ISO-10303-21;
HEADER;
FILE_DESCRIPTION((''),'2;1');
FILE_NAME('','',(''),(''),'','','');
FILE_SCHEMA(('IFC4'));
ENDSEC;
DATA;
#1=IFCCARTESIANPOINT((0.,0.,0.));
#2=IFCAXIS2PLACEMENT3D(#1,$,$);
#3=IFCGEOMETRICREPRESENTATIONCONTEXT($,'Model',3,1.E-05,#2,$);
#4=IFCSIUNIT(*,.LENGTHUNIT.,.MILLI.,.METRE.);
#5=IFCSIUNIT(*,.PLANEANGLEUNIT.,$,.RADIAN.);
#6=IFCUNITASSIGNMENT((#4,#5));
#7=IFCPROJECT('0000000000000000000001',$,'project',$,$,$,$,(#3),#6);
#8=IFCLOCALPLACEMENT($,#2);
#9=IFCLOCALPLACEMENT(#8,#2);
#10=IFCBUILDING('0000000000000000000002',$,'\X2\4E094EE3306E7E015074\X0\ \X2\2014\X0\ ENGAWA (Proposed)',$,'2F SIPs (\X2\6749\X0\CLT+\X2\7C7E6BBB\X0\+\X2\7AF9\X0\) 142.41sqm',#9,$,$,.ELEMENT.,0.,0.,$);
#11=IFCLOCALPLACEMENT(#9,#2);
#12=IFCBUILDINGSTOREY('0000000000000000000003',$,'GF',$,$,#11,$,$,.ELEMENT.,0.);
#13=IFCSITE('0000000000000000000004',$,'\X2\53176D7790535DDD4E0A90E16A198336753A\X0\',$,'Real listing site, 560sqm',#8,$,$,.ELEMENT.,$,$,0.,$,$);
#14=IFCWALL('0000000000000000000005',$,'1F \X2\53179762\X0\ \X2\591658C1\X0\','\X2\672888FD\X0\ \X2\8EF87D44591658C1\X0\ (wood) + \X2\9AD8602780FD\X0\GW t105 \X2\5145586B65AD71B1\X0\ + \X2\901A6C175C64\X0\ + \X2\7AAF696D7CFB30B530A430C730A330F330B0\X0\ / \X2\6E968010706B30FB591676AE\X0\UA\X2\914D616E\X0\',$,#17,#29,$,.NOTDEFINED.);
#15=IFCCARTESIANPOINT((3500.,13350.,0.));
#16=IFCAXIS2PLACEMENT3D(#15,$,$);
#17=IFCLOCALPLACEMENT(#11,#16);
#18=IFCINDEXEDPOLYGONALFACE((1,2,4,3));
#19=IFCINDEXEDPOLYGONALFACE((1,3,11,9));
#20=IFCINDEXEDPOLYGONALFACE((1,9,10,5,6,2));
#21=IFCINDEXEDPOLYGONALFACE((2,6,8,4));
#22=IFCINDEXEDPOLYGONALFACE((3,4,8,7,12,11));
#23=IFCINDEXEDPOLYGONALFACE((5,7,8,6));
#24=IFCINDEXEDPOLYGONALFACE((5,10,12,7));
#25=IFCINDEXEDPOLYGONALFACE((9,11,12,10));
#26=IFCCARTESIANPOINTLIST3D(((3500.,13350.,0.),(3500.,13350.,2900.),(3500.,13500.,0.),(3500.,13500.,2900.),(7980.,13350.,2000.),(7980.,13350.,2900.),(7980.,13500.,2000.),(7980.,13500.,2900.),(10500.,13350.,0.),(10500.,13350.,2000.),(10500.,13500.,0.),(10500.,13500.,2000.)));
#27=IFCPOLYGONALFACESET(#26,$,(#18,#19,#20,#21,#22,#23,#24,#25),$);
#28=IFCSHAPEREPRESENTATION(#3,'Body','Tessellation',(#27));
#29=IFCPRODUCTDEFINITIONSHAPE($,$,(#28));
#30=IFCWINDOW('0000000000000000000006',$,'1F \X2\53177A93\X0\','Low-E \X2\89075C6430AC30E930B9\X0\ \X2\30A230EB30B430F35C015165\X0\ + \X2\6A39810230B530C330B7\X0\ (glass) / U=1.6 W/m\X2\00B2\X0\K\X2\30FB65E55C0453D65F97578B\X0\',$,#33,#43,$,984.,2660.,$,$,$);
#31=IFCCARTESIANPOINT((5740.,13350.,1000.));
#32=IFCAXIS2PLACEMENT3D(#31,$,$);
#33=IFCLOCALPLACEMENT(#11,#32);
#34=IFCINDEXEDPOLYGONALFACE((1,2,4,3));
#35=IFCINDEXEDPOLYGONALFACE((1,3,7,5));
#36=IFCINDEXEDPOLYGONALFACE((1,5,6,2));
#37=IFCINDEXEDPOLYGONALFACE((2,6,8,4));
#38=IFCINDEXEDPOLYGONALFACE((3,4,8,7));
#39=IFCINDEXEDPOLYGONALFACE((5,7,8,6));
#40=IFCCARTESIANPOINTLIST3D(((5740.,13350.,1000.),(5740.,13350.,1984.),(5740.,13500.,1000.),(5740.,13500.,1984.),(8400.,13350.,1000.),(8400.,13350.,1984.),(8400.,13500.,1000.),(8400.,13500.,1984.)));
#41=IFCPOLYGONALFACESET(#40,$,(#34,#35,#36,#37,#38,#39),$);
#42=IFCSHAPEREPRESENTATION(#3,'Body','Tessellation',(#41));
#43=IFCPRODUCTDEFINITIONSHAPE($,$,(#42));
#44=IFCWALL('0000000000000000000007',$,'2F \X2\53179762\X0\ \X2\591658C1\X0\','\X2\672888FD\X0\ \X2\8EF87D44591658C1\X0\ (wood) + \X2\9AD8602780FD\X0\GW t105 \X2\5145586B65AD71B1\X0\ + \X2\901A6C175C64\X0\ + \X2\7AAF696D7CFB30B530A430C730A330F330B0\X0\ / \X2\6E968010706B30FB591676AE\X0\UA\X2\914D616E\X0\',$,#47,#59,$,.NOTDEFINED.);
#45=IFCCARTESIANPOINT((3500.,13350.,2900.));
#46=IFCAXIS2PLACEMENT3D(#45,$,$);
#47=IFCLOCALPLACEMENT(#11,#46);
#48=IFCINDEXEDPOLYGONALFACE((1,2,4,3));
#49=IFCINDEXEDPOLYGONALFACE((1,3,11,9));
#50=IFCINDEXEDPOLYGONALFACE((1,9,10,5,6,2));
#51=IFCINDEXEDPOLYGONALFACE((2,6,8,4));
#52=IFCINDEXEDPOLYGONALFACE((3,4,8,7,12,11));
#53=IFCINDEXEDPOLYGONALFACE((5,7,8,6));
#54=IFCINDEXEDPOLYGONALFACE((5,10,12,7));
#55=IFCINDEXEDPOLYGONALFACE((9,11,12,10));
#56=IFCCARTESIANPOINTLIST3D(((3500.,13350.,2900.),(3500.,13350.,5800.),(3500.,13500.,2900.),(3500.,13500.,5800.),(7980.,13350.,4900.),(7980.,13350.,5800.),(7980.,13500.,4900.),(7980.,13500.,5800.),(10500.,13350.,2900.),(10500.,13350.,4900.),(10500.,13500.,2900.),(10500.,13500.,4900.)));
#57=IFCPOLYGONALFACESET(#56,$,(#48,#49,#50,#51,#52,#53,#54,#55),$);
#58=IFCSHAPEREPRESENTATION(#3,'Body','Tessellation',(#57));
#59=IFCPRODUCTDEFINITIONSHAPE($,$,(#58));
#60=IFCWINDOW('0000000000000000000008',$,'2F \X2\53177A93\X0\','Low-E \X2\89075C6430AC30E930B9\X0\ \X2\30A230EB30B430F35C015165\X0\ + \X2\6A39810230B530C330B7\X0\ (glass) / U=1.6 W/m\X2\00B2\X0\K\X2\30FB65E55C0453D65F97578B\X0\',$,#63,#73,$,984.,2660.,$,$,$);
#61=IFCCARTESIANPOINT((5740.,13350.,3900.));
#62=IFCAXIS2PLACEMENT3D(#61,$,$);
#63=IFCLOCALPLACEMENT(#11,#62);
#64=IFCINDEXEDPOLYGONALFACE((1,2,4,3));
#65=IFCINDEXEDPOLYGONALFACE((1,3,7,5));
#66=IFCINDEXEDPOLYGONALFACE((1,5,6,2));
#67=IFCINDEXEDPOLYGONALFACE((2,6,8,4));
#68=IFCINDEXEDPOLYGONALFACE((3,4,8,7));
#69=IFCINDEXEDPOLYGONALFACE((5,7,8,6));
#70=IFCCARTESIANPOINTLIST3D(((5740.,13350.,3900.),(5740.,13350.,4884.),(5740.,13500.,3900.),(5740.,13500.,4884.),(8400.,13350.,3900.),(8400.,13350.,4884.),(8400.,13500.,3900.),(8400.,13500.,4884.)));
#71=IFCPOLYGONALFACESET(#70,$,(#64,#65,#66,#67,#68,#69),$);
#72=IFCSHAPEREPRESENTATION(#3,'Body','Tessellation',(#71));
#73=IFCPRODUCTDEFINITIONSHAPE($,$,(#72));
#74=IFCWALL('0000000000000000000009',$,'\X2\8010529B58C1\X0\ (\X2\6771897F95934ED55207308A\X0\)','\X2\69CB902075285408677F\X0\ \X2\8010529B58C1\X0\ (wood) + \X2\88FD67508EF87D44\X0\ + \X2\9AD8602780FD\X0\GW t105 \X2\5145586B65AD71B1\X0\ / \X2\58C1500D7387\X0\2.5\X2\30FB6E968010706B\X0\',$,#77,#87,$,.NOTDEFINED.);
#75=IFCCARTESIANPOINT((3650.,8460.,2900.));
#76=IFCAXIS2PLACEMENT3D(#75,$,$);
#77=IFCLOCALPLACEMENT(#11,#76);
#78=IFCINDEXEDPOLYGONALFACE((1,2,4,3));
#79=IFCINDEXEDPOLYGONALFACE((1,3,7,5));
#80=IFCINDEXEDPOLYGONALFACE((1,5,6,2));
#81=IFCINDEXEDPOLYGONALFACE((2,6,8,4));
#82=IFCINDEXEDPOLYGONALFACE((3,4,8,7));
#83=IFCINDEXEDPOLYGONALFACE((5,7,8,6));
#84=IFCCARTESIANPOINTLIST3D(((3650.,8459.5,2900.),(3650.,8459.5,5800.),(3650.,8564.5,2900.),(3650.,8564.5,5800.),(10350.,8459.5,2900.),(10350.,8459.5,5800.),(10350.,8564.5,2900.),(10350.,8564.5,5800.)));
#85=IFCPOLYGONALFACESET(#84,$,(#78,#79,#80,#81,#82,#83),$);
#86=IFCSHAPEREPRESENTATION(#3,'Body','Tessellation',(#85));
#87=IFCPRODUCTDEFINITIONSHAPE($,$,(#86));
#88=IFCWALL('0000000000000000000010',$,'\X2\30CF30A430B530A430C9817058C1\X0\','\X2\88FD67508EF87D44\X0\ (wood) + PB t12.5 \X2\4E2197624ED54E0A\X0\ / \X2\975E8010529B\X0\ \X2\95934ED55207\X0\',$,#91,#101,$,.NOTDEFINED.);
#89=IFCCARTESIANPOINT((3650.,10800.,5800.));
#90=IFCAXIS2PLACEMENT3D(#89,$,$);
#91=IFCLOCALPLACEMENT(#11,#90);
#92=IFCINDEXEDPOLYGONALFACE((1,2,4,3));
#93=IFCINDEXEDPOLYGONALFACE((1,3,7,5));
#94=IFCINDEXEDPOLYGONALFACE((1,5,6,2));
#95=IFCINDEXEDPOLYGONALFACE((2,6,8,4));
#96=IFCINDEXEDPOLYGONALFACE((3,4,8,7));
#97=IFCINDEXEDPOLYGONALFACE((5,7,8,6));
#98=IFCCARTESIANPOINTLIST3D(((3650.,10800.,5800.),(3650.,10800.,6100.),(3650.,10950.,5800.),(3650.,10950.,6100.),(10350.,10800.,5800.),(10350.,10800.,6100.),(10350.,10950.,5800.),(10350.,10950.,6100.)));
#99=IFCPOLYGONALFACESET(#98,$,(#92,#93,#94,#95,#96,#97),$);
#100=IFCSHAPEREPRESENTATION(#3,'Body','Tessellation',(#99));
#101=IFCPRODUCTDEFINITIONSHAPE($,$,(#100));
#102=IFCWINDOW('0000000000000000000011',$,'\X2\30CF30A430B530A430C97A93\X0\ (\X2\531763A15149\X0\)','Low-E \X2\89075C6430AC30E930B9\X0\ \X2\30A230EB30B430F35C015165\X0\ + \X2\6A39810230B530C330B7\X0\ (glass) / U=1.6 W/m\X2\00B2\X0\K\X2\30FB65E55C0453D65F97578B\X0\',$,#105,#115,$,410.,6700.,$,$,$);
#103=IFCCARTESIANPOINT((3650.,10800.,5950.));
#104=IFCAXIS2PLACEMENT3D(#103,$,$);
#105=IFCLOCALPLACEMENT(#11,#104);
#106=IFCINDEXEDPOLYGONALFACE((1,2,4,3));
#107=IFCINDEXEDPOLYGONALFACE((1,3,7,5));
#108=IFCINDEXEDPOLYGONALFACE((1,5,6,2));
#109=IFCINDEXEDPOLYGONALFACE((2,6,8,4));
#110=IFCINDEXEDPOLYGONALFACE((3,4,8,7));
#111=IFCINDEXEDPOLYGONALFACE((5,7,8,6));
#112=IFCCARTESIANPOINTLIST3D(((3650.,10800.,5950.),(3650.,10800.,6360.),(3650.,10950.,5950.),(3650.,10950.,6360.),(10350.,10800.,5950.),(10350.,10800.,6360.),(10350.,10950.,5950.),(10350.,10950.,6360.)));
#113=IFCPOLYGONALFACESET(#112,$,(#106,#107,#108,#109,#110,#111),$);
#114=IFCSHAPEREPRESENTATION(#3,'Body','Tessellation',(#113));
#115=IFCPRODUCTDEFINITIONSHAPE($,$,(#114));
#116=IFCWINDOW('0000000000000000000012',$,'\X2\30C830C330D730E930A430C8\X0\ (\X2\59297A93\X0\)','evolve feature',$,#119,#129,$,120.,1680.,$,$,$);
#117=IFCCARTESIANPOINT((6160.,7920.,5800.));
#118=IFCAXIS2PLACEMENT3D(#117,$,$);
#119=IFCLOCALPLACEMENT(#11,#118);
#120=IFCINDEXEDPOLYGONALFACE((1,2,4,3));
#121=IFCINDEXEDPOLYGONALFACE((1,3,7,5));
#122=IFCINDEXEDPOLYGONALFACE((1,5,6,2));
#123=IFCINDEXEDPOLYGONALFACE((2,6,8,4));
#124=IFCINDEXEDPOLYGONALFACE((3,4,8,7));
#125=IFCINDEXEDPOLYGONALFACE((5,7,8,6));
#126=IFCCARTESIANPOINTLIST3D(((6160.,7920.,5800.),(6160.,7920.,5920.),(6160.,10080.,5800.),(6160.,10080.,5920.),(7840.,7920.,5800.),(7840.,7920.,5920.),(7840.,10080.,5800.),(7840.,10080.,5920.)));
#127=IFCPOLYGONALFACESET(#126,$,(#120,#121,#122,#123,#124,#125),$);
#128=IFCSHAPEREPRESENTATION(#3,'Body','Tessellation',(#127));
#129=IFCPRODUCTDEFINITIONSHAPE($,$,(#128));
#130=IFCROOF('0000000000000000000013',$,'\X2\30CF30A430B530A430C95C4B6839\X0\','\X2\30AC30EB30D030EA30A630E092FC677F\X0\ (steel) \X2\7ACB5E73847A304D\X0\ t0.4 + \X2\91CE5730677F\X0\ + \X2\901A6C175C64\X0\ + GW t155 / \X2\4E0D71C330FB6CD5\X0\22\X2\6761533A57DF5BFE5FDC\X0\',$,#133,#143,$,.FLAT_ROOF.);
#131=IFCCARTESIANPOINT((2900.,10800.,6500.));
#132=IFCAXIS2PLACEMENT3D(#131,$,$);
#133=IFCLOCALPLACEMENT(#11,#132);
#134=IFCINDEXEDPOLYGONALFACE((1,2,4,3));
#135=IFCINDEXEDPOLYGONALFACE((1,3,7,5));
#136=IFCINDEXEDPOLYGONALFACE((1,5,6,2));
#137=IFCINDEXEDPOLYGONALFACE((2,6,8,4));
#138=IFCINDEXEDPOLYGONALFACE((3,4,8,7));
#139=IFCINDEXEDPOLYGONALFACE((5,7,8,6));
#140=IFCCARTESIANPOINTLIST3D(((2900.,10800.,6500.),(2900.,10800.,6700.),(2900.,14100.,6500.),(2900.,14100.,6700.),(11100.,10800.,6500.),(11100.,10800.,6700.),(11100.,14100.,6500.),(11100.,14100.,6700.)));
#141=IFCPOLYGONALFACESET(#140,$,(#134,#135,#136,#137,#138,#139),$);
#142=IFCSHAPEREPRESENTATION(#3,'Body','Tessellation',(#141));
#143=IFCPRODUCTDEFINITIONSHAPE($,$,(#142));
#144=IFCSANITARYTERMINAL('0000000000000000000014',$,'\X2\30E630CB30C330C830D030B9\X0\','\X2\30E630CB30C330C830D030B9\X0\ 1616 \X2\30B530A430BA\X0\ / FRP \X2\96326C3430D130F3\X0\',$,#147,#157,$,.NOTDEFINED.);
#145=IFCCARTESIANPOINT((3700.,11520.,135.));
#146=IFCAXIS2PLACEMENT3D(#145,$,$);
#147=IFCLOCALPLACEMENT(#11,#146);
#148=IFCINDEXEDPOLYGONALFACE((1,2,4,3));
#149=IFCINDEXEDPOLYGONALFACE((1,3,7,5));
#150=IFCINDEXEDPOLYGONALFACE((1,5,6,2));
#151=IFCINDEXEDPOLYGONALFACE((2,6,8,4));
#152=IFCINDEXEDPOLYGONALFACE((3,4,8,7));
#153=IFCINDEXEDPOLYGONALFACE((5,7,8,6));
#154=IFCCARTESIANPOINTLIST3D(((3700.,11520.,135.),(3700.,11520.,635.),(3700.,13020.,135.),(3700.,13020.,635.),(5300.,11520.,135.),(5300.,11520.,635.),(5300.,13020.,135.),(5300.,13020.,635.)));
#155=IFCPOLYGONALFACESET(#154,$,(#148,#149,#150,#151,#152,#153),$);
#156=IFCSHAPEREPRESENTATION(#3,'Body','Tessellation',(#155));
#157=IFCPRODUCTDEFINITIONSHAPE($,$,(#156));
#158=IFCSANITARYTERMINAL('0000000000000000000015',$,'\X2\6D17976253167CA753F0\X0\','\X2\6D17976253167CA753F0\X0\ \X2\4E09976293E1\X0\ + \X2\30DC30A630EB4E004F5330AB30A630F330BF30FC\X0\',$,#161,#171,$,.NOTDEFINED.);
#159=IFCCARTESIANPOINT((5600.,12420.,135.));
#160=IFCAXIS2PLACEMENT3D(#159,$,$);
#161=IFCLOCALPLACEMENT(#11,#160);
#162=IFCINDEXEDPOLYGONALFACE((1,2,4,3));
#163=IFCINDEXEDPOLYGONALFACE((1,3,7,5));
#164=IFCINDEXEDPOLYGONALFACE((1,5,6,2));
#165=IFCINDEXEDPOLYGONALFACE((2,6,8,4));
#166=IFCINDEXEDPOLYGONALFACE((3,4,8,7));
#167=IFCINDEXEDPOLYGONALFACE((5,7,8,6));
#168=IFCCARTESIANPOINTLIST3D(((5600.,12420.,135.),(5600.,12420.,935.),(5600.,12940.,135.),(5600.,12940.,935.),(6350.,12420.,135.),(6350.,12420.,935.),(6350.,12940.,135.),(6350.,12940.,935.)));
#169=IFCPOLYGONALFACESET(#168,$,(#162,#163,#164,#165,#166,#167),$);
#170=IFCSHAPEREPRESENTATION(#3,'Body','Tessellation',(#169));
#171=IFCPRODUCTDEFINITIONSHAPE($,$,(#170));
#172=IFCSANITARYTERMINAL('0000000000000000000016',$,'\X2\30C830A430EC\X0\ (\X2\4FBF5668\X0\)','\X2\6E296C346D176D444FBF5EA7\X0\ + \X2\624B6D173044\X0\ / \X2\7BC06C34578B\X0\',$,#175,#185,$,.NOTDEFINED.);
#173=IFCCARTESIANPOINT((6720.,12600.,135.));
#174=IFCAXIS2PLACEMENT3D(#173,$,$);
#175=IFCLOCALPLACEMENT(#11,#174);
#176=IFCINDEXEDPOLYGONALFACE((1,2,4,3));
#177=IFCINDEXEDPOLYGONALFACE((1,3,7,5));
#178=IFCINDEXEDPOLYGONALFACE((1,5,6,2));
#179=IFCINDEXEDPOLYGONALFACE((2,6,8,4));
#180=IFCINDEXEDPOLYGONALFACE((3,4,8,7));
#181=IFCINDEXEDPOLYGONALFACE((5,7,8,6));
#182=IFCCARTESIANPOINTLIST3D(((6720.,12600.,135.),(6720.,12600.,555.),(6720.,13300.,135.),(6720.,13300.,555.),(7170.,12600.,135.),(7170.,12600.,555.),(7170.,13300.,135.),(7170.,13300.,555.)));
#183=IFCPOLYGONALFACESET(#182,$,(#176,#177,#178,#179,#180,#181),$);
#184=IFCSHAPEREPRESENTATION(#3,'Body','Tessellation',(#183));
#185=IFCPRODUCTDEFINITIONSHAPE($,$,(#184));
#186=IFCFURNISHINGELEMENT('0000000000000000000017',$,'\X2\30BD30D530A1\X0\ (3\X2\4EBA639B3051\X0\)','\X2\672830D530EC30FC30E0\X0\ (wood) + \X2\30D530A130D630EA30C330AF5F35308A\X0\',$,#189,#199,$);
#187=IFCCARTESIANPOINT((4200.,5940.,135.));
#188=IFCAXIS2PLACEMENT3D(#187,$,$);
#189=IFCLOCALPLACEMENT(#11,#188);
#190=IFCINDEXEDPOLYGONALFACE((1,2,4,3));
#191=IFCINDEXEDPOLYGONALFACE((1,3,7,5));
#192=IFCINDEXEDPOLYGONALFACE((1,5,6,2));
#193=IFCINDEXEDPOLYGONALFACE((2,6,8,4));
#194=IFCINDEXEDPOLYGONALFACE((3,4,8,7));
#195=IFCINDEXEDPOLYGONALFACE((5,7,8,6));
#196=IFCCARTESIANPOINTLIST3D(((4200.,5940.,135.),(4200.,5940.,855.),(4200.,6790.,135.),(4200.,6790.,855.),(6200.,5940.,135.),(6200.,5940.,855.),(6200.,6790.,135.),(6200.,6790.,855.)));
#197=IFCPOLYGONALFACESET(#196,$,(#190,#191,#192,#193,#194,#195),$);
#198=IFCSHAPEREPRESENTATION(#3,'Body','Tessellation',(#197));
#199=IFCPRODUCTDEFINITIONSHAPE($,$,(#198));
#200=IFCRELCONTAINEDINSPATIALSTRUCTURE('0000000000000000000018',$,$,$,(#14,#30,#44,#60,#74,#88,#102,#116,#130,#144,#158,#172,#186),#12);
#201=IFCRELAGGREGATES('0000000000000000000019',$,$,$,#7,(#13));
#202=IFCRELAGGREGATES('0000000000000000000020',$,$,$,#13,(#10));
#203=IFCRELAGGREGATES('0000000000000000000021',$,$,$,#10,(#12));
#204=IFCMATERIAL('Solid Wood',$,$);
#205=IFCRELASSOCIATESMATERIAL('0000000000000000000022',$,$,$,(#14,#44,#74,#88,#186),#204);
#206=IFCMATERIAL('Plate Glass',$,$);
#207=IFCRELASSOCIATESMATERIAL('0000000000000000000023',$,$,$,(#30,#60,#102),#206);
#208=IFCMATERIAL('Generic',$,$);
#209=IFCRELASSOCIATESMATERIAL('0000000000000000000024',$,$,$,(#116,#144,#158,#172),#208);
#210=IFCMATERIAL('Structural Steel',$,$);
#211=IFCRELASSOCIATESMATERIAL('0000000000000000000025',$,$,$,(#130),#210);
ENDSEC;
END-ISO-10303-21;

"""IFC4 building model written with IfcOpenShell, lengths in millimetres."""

from ifc_helpers import new_model, si_unit, frame, frame_2d, origin, place, context, project, spatial, rectangle, extrude, material, element, fill, save


model = new_model("IFC4")

# Units and contexts
model_context = context("Model", 3, precision=1e-05, world=origin())
ifc_project = project(units=[si_unit("LENGTHUNIT", "METRE", prefix="MILLI"), si_unit("PLANEANGLEUNIT", "RADIAN")], contexts=[model_context])

# Site, building, storey
site_placement = place(None, origin())
site = spatial("IfcSite", under=ifc_project, at=site_placement, Name="北海道川上郡標茶町", ObjectType="Real listing site, 560sqm", CompositionType="ELEMENT", RefElevation=0.0)
building_placement = place(site_placement, origin())
building = spatial("IfcBuilding", under=site, at=building_placement, Name="三代の縁側 — ENGAWA (Proposed)", ObjectType="2F SIPs (杉CLT+籾殻+竹) 142.41sqm", CompositionType="ELEMENT", ElevationOfRefHeight=0.0, ElevationOfTerrain=0.0)
storey_placement = place(building_placement, origin())
storey = spatial("IfcBuildingStorey", under=building, at=storey_placement, Name="GF", CompositionType="ELEMENT", Elevation=0.0)

# Wall, opening, window
ifc_material_1 = material(Name="Solid Wood")
wall_1_placement = place(storey_placement, frame((3500.0, 13350.0, 0.0)))
wall_1 = element("IfcWall", 1, at=wall_1_placement, inside=storey, material=ifc_material_1, Name="1F 北面 外壁", Description="木製 軸組外壁 (wood) + 高性能GW t105 充填断熱 + 通気層 + 窯業系サイディング / 準耐火・外皮UA配慮", PredefinedType="NOTDEFINED", context=model_context, shape_type="SweptSolid", body=[
    extrude(rectangle(XDim=7000.0, YDim=150.0, at=frame_2d((3500.0, 75.0))), frame((3500.0, 13350.0, 0.0)), (0.0, 0.0, 1.0), 2900.0),
])
opening_1_placement = place(storey_placement, frame((5740.0, 13350.0, 1000.0)))
opening_1 = element("IfcOpeningElement", 2, at=opening_1_placement, cuts=wall_1, PredefinedType="NOTDEFINED", context=model_context, shape_type="SweptSolid", body=[
    extrude(rectangle(XDim=2660.0, YDim=150.0, at=frame_2d((1330.0, 75.0))), frame((5740.0, 13350.0, 1000.0)), (0.0, 0.0, 1.0), 984.0),
])
ifc_material_2 = material(Name="Plate Glass")
window_1_placement = place(storey_placement, frame((5740.0, 13350.0, 1000.0)))
window_1 = element("IfcWindow", 3, at=window_1_placement, inside=storey, material=ifc_material_2, Name="1F 北窓", Description="Low-E 複層ガラス アルゴン封入 + 樹脂サッシ (glass) / U=1.6 W/m²K・日射取得型", OverallHeight=984.0, OverallWidth=2660.0, context=model_context, shape_type="SweptSolid", body=[
    extrude(rectangle(XDim=2660.0, YDim=150.0, at=frame_2d((1330.0, 75.0))), frame((5740.0, 13350.0, 1000.0)), (0.0, 0.0, 1.0), 984.0),
])
fill(opening_1, window_1)

# Wall, opening, window
wall_2_placement = place(storey_placement, frame((3500.0, 13350.0, 2900.0)))
wall_2 = element("IfcWall", 4, at=wall_2_placement, inside=storey, material=ifc_material_1, Name="2F 北面 外壁", Description="木製 軸組外壁 (wood) + 高性能GW t105 充填断熱 + 通気層 + 窯業系サイディング / 準耐火・外皮UA配慮", PredefinedType="NOTDEFINED", context=model_context, shape_type="SweptSolid", body=[
    extrude(rectangle(XDim=7000.0, YDim=150.0, at=frame_2d((3500.0, 75.0))), frame((3500.0, 13350.0, 2900.0)), (0.0, 0.0, 1.0), 2900.0),
])
opening_2_placement = place(storey_placement, frame((5740.0, 13350.0, 3900.0)))
opening_2 = element("IfcOpeningElement", 5, at=opening_2_placement, cuts=wall_2, PredefinedType="NOTDEFINED", context=model_context, shape_type="SweptSolid", body=[
    extrude(rectangle(XDim=2660.0, YDim=150.0, at=frame_2d((1330.0, 75.0))), frame((5740.0, 13350.0, 3900.0)), (0.0, 0.0, 1.0), 984.0),
])
window_2_placement = place(storey_placement, frame((5740.0, 13350.0, 3900.0)))
window_2 = element("IfcWindow", 6, at=window_2_placement, inside=storey, material=ifc_material_2, Name="2F 北窓", Description="Low-E 複層ガラス アルゴン封入 + 樹脂サッシ (glass) / U=1.6 W/m²K・日射取得型", OverallHeight=984.0, OverallWidth=2660.0, context=model_context, shape_type="SweptSolid", body=[
    extrude(rectangle(XDim=2660.0, YDim=150.0, at=frame_2d((1330.0, 75.0))), frame((5740.0, 13350.0, 3900.0)), (0.0, 0.0, 1.0), 984.0),
])
fill(opening_2, window_2)

# Wall
wall_3_placement = place(storey_placement, frame((3650.0, 8460.0, 2900.0)))
element("IfcWall", 7, at=wall_3_placement, inside=storey, material=ifc_material_1, Name="耐力壁 (東西間仕切り)", Description="構造用合板 耐力壁 (wood) + 製材軸組 + 高性能GW t105 充填断熱 / 壁倍率2.5・準耐火", PredefinedType="NOTDEFINED", context=model_context, shape_type="SweptSolid", body=[
    extrude(rectangle(XDim=6700.0, YDim=105.0, at=frame_2d((3350.0, 52.0))), frame((3650.0, 8460.0, 2900.0)), (0.0, 0.0, 1.0), 2900.0),
])

# Wall, opening, window
wall_4_placement = place(storey_placement, frame((3650.0, 10800.0, 5800.0)))
wall_4 = element("IfcWall", 8, at=wall_4_placement, inside=storey, material=ifc_material_1, Name="ハイサイド腰壁", Description="製材軸組 (wood) + PB t12.5 両面仕上 / 非耐力 間仕切", PredefinedType="NOTDEFINED", context=model_context, shape_type="SweptSolid", body=[
    extrude(rectangle(XDim=6700.0, YDim=150.0, at=frame_2d((3350.0, 75.0))), frame((3650.0, 10800.0, 5800.0)), (0.0, 0.0, 1.0), 700.0),
])
opening_3_placement = place(storey_placement, frame((3650.0, 10800.0, 5950.0)))
opening_3 = element("IfcOpeningElement", 9, at=opening_3_placement, cuts=wall_4, PredefinedType="NOTDEFINED", context=model_context, shape_type="SweptSolid", body=[
    extrude(rectangle(XDim=6700.0, YDim=150.0, at=frame_2d((3350.0, 75.0))), frame((3650.0, 10800.0, 5950.0)), (0.0, 0.0, 1.0), 410.0),
])
window_3_placement = place(storey_placement, frame((3650.0, 10800.0, 5950.0)))
window_3 = element("IfcWindow", 10, at=window_3_placement, inside=storey, material=ifc_material_2, Name="ハイサイド窓 (北採光)", Description="Low-E 複層ガラス アルゴン封入 + 樹脂サッシ (glass) / U=1.6 W/m²K・日射取得型", OverallHeight=410.0, OverallWidth=6700.0, context=model_context, shape_type="SweptSolid", body=[
    extrude(rectangle(XDim=6700.0, YDim=150.0, at=frame_2d((3350.0, 75.0))), frame((3650.0, 10800.0, 5950.0)), (0.0, 0.0, 1.0), 410.0),
])
fill(opening_3, window_3)

# Window
ifc_material_3 = material(Name="Generic")
window_4_placement = place(storey_placement, frame((6160.0, 7920.0, 5800.0)))
element("IfcWindow", 11, at=window_4_placement, inside=storey, material=ifc_material_3, Name="トップライト (天窓)", Description="evolve feature", OverallHeight=120.0, OverallWidth=1680.0, context=model_context, shape_type="SweptSolid", body=[
    extrude(rectangle(XDim=1680.0, YDim=2160.0, at=frame_2d((840.0, 1080.0))), frame((6160.0, 7920.0, 5800.0)), (0.0, 0.0, 1.0), 120.0),
])

# Roof
ifc_material_4 = material(Name="Structural Steel")
roof_placement = place(storey_placement, frame((2900.0, 10800.0, 6500.0)))
element("IfcRoof", 12, at=roof_placement, inside=storey, material=ifc_material_4, Name="ハイサイド屋根", Description="ガルバリウム鋼板 (steel) 立平葺き t0.4 + 野地板 + 通気層 + GW t155 / 不燃・法22条区域対応", PredefinedType="FLAT_ROOF", context=model_context, shape_type="SweptSolid", body=[
    extrude(rectangle(XDim=8200.0, YDim=3300.0, at=frame_2d((4100.0, 1650.0))), frame((2900.0, 10800.0, 6500.0)), (0.0, 0.0, 1.0), 200.0),
])

# Sanitary terminals
sanitary_terminal_1_placement = place(storey_placement, frame((3700.0, 11520.0, 135.0)))
element("IfcSanitaryTerminal", 13, at=sanitary_terminal_1_placement, inside=storey, material=ifc_material_3, Name="ユニットバス", Description="ユニットバス 1616 サイズ / FRP 防水パン", PredefinedType="NOTDEFINED", context=model_context, shape_type="SweptSolid", body=[
    extrude(rectangle(XDim=1600.0, YDim=1500.0, at=frame_2d((800.0, 750.0))), frame((3700.0, 11520.0, 135.0)), (0.0, 0.0, 1.0), 500.0),
])
sanitary_terminal_2_placement = place(storey_placement, frame((5600.0, 12420.0, 135.0)))
element("IfcSanitaryTerminal", 14, at=sanitary_terminal_2_placement, inside=storey, material=ifc_material_3, Name="洗面化粧台", Description="洗面化粧台 三面鏡 + ボウル一体カウンター", PredefinedType="NOTDEFINED", context=model_context, shape_type="SweptSolid", body=[
    extrude(rectangle(XDim=750.0, YDim=520.0, at=frame_2d((375.0, 260.0))), frame((5600.0, 12420.0, 135.0)), (0.0, 0.0, 1.0), 800.0),
])
sanitary_terminal_3_placement = place(storey_placement, frame((6720.0, 12600.0, 135.0)))
element("IfcSanitaryTerminal", 15, at=sanitary_terminal_3_placement, inside=storey, material=ifc_material_3, Name="トイレ (便器)", Description="温水洗浄便座 + 手洗い / 節水型", PredefinedType="NOTDEFINED", context=model_context, shape_type="SweptSolid", body=[
    extrude(rectangle(XDim=450.0, YDim=700.0, at=frame_2d((225.0, 350.0))), frame((6720.0, 12600.0, 135.0)), (0.0, 0.0, 1.0), 420.0),
])

# Furnishing element
furnishing_1_placement = place(storey_placement, frame((4200.0, 5940.0, 135.0)))
element("IfcFurnishingElement", 16, at=furnishing_1_placement, inside=storey, material=ifc_material_1, Name="ソファ (3人掛け)", Description="木フレーム (wood) + ファブリック張り", context=model_context, shape_type="SweptSolid", body=[
    extrude(rectangle(XDim=2000.0, YDim=850.0, at=frame_2d((1000.0, 425.0))), frame((4200.0, 5940.0, 135.0)), (0.0, 0.0, 1.0), 720.0),
])

save(model, "model.ifc")
